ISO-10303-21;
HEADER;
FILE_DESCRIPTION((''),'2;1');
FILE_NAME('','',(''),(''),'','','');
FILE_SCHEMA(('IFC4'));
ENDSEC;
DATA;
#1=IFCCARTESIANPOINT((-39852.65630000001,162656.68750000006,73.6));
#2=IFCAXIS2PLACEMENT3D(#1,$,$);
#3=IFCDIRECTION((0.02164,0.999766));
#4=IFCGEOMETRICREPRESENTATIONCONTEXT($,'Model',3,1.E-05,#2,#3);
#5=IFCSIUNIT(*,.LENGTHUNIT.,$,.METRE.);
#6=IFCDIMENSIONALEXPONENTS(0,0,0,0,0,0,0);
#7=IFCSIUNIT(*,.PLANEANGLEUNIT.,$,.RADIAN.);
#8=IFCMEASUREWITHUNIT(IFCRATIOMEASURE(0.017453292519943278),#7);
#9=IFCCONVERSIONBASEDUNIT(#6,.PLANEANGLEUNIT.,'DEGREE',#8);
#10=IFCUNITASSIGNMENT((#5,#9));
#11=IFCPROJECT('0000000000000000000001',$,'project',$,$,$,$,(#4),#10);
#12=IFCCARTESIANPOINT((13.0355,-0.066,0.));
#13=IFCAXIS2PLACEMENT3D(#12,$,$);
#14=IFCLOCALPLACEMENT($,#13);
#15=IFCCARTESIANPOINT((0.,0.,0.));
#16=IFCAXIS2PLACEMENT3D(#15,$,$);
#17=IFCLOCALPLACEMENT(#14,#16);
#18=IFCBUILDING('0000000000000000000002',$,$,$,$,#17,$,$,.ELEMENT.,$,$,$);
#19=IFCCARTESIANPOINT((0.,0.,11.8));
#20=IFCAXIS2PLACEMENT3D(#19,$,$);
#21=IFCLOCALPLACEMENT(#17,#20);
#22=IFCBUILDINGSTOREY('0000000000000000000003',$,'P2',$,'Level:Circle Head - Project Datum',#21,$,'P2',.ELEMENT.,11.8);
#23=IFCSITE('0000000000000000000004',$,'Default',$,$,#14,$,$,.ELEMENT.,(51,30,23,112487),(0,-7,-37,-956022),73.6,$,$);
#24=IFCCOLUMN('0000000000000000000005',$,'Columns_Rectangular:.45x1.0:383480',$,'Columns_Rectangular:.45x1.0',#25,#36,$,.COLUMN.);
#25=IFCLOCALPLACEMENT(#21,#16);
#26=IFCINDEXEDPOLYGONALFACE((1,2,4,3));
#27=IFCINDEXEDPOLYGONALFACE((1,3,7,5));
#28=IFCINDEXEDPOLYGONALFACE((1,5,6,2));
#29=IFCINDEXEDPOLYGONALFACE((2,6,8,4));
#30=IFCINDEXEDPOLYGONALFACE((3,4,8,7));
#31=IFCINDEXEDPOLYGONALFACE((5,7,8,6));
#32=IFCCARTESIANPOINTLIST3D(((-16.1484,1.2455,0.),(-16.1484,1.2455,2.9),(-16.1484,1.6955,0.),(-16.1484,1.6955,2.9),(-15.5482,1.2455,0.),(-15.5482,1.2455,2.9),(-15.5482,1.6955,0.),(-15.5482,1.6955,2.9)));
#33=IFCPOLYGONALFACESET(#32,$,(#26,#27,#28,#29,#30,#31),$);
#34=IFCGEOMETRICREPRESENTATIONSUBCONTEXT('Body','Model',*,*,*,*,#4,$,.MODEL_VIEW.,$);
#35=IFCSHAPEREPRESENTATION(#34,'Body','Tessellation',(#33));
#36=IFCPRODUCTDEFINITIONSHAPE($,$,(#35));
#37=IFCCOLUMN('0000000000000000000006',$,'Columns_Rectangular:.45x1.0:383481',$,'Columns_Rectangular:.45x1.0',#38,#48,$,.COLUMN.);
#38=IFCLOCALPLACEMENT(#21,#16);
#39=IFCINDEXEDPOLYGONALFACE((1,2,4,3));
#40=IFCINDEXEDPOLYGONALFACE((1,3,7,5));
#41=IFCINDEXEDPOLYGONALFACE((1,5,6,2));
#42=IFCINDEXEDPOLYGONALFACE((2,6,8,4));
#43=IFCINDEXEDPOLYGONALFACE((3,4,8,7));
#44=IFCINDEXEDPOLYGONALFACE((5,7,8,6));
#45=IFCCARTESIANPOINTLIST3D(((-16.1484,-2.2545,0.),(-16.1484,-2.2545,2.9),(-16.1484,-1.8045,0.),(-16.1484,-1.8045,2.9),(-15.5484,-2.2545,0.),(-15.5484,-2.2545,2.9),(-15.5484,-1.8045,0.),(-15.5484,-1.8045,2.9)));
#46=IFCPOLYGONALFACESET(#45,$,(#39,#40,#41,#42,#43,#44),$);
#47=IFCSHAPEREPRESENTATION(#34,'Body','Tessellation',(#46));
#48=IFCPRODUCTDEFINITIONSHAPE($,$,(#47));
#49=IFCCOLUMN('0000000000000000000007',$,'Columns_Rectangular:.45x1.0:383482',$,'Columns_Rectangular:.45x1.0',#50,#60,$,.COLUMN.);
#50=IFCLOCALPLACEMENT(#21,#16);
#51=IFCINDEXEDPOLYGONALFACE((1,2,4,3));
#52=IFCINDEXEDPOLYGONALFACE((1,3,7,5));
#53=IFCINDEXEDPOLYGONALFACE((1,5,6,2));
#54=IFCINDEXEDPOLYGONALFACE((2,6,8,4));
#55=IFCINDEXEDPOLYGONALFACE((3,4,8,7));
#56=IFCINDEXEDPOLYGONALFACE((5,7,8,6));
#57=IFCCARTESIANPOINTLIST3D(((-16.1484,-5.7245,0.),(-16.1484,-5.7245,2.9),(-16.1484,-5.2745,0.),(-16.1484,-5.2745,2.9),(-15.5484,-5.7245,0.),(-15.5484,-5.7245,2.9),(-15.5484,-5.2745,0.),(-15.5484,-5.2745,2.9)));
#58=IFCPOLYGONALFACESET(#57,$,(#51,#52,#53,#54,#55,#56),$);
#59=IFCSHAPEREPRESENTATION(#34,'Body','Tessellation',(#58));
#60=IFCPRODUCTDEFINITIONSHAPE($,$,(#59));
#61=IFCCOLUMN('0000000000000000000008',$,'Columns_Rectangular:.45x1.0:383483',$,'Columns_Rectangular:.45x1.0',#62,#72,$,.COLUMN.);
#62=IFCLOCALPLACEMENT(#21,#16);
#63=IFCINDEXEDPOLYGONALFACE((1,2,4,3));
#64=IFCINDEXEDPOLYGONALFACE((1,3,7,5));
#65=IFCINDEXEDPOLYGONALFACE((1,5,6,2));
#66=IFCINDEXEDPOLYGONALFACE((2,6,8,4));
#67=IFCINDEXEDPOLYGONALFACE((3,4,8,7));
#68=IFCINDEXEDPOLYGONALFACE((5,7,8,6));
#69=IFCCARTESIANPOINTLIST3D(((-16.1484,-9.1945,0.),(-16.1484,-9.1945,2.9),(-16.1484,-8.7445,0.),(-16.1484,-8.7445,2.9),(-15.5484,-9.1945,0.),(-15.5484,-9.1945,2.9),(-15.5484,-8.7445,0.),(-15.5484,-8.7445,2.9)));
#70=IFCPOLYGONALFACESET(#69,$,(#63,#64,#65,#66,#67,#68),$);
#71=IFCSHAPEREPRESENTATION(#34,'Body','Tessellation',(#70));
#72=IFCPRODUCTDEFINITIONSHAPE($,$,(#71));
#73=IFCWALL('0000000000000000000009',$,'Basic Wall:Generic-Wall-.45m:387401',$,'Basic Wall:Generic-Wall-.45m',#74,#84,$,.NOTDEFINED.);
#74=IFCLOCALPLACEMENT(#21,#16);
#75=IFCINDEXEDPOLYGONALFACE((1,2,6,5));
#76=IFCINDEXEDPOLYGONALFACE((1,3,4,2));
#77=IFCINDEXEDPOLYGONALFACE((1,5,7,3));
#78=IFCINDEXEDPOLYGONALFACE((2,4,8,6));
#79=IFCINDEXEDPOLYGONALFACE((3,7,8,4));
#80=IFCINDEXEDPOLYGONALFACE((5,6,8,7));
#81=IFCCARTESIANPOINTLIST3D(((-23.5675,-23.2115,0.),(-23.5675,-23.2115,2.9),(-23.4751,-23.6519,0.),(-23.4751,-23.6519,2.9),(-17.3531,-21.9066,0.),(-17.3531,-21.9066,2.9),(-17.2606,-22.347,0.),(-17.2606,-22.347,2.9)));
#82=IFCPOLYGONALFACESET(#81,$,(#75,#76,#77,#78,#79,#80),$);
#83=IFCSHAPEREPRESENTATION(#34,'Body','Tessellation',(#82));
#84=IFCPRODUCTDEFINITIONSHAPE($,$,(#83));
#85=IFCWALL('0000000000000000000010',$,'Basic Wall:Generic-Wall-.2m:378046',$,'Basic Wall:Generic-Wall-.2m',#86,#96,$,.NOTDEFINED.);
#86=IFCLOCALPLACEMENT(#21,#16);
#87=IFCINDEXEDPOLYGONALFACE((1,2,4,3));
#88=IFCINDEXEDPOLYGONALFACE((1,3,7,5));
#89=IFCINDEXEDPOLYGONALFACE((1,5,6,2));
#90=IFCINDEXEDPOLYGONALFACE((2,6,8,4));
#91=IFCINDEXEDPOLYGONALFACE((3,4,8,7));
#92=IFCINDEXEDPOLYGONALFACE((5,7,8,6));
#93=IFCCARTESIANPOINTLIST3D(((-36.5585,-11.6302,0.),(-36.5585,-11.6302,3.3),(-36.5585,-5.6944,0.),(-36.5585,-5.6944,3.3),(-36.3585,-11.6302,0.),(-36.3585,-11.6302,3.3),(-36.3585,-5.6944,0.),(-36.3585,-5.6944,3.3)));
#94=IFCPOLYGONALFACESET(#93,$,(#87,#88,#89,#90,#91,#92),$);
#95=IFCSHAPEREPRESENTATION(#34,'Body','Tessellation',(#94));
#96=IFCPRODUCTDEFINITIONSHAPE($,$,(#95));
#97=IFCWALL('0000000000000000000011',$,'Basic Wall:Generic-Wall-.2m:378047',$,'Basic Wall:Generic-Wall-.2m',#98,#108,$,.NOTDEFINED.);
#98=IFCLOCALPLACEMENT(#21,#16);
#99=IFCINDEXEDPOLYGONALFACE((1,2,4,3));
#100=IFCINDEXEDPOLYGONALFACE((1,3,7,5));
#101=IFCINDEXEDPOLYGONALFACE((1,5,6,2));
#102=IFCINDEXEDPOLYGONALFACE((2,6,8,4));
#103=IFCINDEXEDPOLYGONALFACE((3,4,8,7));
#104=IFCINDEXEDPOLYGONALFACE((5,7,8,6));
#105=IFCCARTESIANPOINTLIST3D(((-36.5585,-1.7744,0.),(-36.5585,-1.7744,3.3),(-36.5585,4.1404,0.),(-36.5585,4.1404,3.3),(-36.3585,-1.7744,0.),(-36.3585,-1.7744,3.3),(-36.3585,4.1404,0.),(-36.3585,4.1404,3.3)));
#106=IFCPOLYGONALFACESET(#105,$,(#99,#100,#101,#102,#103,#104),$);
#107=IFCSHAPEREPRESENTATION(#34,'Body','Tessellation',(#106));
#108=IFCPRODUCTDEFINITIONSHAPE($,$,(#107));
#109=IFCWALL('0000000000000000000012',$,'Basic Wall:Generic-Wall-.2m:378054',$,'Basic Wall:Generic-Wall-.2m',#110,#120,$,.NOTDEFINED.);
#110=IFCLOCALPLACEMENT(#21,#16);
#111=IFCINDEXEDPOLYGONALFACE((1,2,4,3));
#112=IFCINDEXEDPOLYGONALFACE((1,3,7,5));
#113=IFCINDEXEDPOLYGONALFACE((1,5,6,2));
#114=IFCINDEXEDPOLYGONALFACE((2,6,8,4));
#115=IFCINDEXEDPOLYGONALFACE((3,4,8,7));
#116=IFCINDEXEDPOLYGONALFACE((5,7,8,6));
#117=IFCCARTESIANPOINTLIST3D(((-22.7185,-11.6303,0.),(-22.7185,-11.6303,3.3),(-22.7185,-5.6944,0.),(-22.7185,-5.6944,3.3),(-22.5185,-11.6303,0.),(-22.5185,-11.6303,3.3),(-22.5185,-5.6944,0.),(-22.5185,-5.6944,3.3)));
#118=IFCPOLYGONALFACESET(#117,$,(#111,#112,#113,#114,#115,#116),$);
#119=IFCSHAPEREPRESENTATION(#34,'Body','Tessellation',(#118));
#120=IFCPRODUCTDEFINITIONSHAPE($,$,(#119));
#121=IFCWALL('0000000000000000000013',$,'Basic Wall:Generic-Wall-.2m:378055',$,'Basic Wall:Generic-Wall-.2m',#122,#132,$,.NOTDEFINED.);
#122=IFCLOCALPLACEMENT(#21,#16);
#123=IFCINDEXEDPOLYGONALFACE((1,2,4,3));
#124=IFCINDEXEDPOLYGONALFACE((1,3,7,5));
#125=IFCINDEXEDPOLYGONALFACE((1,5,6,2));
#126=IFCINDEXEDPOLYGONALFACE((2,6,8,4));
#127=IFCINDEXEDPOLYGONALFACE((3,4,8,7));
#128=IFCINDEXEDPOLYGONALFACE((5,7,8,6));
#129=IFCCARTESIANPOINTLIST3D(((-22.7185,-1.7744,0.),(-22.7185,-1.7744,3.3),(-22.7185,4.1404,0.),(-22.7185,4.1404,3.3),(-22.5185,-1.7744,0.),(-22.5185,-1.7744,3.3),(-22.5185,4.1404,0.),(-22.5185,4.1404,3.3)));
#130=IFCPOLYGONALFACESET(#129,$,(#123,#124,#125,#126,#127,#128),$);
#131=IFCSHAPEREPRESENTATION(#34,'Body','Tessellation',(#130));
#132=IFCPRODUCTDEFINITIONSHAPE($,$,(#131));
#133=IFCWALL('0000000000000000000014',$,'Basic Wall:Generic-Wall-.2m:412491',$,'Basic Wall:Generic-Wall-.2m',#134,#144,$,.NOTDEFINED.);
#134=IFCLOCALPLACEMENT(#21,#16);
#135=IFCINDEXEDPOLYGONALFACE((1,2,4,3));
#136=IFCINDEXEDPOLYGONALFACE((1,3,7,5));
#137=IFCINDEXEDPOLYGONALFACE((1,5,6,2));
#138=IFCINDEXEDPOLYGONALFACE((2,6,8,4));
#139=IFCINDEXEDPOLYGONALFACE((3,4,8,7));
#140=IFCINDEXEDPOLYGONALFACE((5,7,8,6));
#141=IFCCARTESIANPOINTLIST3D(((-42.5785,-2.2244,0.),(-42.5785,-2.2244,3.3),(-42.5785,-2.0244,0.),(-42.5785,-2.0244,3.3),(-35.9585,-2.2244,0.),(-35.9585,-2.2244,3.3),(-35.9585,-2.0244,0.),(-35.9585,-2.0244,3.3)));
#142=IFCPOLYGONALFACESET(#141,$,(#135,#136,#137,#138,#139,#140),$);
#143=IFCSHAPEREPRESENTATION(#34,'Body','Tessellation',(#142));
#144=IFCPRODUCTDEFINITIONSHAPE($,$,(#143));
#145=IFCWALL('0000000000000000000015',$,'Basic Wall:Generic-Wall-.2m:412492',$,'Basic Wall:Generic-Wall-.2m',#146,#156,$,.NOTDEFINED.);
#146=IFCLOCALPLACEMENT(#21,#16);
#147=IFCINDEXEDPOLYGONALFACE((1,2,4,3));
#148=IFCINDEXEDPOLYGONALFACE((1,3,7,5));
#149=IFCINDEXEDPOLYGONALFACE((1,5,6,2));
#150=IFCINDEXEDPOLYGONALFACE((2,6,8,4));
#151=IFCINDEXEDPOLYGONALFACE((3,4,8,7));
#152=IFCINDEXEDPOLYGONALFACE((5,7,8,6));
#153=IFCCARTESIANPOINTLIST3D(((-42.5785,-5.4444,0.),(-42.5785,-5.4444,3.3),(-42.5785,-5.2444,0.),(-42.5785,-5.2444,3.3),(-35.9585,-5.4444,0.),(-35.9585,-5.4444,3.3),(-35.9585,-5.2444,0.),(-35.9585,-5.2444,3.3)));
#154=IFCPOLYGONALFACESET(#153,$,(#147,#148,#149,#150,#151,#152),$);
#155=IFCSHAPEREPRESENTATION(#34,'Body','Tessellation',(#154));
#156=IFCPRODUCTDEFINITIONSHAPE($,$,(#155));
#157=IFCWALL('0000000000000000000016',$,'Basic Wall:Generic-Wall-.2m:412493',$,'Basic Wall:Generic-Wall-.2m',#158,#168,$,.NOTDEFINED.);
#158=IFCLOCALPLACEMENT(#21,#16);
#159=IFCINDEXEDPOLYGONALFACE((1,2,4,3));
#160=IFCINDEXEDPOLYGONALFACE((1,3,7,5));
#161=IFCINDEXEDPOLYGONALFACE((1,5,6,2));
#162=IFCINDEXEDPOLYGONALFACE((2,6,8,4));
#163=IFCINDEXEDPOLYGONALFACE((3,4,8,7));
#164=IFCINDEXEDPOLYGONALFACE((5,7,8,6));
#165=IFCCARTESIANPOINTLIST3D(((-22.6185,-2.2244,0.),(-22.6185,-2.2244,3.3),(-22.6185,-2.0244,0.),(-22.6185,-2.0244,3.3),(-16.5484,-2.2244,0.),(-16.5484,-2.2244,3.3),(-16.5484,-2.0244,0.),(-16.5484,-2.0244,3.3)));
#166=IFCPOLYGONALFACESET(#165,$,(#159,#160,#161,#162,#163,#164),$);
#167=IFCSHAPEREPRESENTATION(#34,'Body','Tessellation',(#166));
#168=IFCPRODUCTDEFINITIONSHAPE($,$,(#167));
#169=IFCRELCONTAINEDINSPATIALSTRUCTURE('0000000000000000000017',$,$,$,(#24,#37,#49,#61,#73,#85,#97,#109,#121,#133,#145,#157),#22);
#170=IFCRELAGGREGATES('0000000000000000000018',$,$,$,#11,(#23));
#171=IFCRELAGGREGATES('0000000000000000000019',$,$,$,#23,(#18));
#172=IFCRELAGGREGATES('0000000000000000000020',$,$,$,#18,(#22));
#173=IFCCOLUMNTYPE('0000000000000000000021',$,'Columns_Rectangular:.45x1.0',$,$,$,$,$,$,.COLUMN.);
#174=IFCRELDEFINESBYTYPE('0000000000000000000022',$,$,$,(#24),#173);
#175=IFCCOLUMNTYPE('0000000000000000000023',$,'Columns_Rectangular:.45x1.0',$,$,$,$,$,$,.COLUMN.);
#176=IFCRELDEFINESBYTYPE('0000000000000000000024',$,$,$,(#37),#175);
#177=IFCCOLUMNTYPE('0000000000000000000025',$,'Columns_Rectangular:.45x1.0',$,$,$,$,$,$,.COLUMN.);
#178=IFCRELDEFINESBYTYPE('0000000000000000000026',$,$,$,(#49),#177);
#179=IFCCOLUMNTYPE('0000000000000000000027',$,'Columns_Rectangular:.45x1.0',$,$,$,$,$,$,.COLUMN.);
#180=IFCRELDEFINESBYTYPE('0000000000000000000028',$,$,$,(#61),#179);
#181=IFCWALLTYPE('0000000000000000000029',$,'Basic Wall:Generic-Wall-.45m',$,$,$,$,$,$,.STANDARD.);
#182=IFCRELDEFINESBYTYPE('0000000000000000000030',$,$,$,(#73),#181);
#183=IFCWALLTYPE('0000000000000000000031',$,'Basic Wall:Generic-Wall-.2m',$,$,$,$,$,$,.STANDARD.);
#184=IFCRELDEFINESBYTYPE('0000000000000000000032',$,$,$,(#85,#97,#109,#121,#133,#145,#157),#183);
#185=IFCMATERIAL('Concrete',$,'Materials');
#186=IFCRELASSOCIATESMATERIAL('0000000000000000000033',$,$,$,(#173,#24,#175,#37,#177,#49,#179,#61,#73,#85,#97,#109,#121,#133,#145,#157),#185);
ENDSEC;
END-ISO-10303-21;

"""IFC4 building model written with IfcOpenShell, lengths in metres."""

from ifc_helpers import new_model, entity, si_unit, converted_unit, direction, frame, origin, place, context, subcontext, project, spatial, indexed_curve, outline, extrude, source, transform, mapped, material, type_object, type_shapes, element, save


model = new_model("IFC4")

# Units and contexts
model_context = context("Model", 3, precision=1e-05, world=frame((-39852.65630000001, 162656.68750000006, 73.6)), true_north=direction((0.02164, 0.999766)))
body_context = subcontext(model_context, "Body", "Model", "MODEL_VIEW")
ifc_project = project(units=[si_unit("LENGTHUNIT", "METRE"), converted_unit("PLANEANGLEUNIT", "DEGREE", entity("IfcRatioMeasure", 0.017453292519943278), si_unit("PLANEANGLEUNIT", "RADIAN"), dimensions=[0, 0, 0, 0, 0, 0, 0])], contexts=[model_context])

# Site, building, storey
site_placement = place(None, frame((13.0355, -0.066, 0.0)))
site = spatial("IfcSite", under=ifc_project, at=site_placement, Name="Default", CompositionType="ELEMENT", RefLatitude=(51, 30, 23, 112487), RefLongitude=(0, -7, -37, -956022), RefElevation=73.6)
building_placement = place(site_placement, origin())
building = spatial("IfcBuilding", under=site, at=building_placement, CompositionType="ELEMENT")
storey_placement = place(building_placement, frame((0.0, 0.0, 11.8)))
storey = spatial("IfcBuildingStorey", under=building, at=storey_placement, Name="P2", ObjectType="Level:Circle Head - Project Datum", LongName="P2", CompositionType="ELEMENT", Elevation=11.8)

# Columns
ifc_material = material(Name="Concrete", Category="Materials")
column_type_1 = type_object("IfcColumnType", Name="Columns_Rectangular:.45x1.0", PredefinedType="COLUMN", material=ifc_material)
shared_shape_1 = source(origin(), body_context, "Body", "SweptSolid", [
    extrude(outline(indexed_curve([(-0.225, -0.3001), (0.225, -0.3001), (0.225, 0.3001), (-0.225, 0.3001), (-0.225, -0.3001)], self_intersect=False)), frame((-15.8483, 1.4705, 11.8), z_axis=(0.0, 0.0, 1.0), x_axis=(0.0, -1.0, 0.0)), (0.0, 0.0, 1.0), 2.9),
])
type_shapes(column_type_1, [shared_shape_1])
column_1_placement = place(storey_placement, frame((0.0, 0.0, -11.8)))
element("IfcColumn", 1, at=column_1_placement, inside=storey, type_object=column_type_1, material=ifc_material, Name="Columns_Rectangular:.45x1.0:383480", ObjectType="Columns_Rectangular:.45x1.0", PredefinedType="COLUMN", context=body_context, shape_type="MappedRepresentation", body=[
    mapped(shared_shape_1, transform((0.0, 0.0, 0.0), scale=1.0)),
])
column_type_2 = type_object("IfcColumnType", Name="Columns_Rectangular:.45x1.0", PredefinedType="COLUMN", material=ifc_material)
shared_shape_2 = source(origin(), body_context, "Body", "SweptSolid", [
    extrude(outline(indexed_curve([(-0.225, -0.3), (0.225, -0.3), (0.225, 0.3), (-0.225, 0.3), (-0.225, -0.3)], self_intersect=False)), frame((-15.8484, -2.0295, 11.8), z_axis=(0.0, 0.0, 1.0), x_axis=(0.0, -1.0, 0.0)), (0.0, 0.0, 1.0), 2.9),
])
type_shapes(column_type_2, [shared_shape_2])
column_2_placement = place(storey_placement, frame((0.0, 0.0, -11.8)))
element("IfcColumn", 2, at=column_2_placement, inside=storey, type_object=column_type_2, material=ifc_material, Name="Columns_Rectangular:.45x1.0:383481", ObjectType="Columns_Rectangular:.45x1.0", PredefinedType="COLUMN", context=body_context, shape_type="MappedRepresentation", body=[
    mapped(shared_shape_2, transform((0.0, 0.0, 0.0), scale=1.0)),
])
column_type_3 = type_object("IfcColumnType", Name="Columns_Rectangular:.45x1.0", PredefinedType="COLUMN", material=ifc_material)
shared_shape_3 = source(origin(), body_context, "Body", "SweptSolid", [
    extrude(outline(indexed_curve([(-0.225, -0.3), (0.225, -0.3), (0.225, 0.3), (-0.225, 0.3), (-0.225, -0.3)], self_intersect=False)), frame((-15.8484, -5.4995, 11.8), z_axis=(0.0, 0.0, 1.0), x_axis=(0.0, -1.0, 0.0)), (0.0, 0.0, 1.0), 2.9),
])
type_shapes(column_type_3, [shared_shape_3])
column_3_placement = place(storey_placement, frame((0.0, 0.0, -11.8)))
element("IfcColumn", 3, at=column_3_placement, inside=storey, type_object=column_type_3, material=ifc_material, Name="Columns_Rectangular:.45x1.0:383482", ObjectType="Columns_Rectangular:.45x1.0", PredefinedType="COLUMN", context=body_context, shape_type="MappedRepresentation", body=[
    mapped(shared_shape_3, transform((0.0, 0.0, 0.0), scale=1.0)),
])
column_type_4 = type_object("IfcColumnType", Name="Columns_Rectangular:.45x1.0", PredefinedType="COLUMN", material=ifc_material)
shared_shape_4 = source(origin(), body_context, "Body", "SweptSolid", [
    extrude(outline(indexed_curve([(-0.225, -0.3), (0.225, -0.3), (0.225, 0.3), (-0.225, 0.3), (-0.225, -0.3)], self_intersect=False)), frame((-15.8484, -8.9695, 11.8), z_axis=(0.0, 0.0, 1.0), x_axis=(0.0, -1.0, 0.0)), (0.0, 0.0, 1.0), 2.9),
])
type_shapes(column_type_4, [shared_shape_4])
column_4_placement = place(storey_placement, frame((0.0, 0.0, -11.8)))
element("IfcColumn", 4, at=column_4_placement, inside=storey, type_object=column_type_4, material=ifc_material, Name="Columns_Rectangular:.45x1.0:383483", ObjectType="Columns_Rectangular:.45x1.0", PredefinedType="COLUMN", context=body_context, shape_type="MappedRepresentation", body=[
    mapped(shared_shape_4, transform((0.0, 0.0, 0.0), scale=1.0)),
])

# Walls
wall_type_1 = type_object("IfcWallType", Name="Basic Wall:Generic-Wall-.45m", PredefinedType="STANDARD")
wall_1_placement = place(storey_placement, frame((-23.5213, -23.4317, 0.0), z_axis=(0.0, 0.0, 1.0), x_axis=(0.978657, 0.2055, 0.0)))
element("IfcWall", 5, at=wall_1_placement, inside=storey, type_object=wall_type_1, material=ifc_material, Name="Basic Wall:Generic-Wall-.45m:387401", ObjectType="Basic Wall:Generic-Wall-.45m", PredefinedType="NOTDEFINED", context=body_context, shape_type="SweptSolid", body=[
    extrude(outline(indexed_curve([(6.35, 0.225), (0.0, 0.225), (0.0, -0.225), (6.35, -0.225), (6.35, 0.225)], self_intersect=False)), origin(), (0.0, 0.0, 1.0), 2.9),
])
wall_type_2 = type_object("IfcWallType", Name="Basic Wall:Generic-Wall-.2m", PredefinedType="STANDARD")
wall_2_placement = place(storey_placement, frame((-36.4585, -5.6944, 0.0), z_axis=(0.0, 0.0, 1.0), x_axis=(0.0, -1.0, 0.0)))
element("IfcWall", 6, at=wall_2_placement, inside=storey, type_object=wall_type_2, material=ifc_material, Name="Basic Wall:Generic-Wall-.2m:378046", ObjectType="Basic Wall:Generic-Wall-.2m", PredefinedType="NOTDEFINED", context=body_context, shape_type="SweptSolid", body=[
    extrude(outline(indexed_curve([(5.9357, 0.1), (0.0, 0.1), (0.0, -0.1), (5.9357, -0.1), (5.9357, 0.1)], self_intersect=False)), origin(), (0.0, 0.0, 1.0), 3.3),
])
wall_3_placement = place(storey_placement, frame((-36.4585, -1.7744, 0.0), z_axis=(0.0, 0.0, 1.0), x_axis=(0.0, 1.0, 0.0)))
element("IfcWall", 7, at=wall_3_placement, inside=storey, type_object=wall_type_2, material=ifc_material, Name="Basic Wall:Generic-Wall-.2m:378047", ObjectType="Basic Wall:Generic-Wall-.2m", PredefinedType="NOTDEFINED", context=body_context, shape_type="SweptSolid", body=[
    extrude(outline(indexed_curve([(5.9149, 0.1), (0.0, 0.1), (0.0, -0.1), (5.9149, -0.1), (5.9149, 0.1)], self_intersect=False)), origin(), (0.0, 0.0, 1.0), 3.3),
])
wall_4_placement = place(storey_placement, frame((-22.6185, -5.6944, 0.0), z_axis=(0.0, 0.0, 1.0), x_axis=(0.0, -1.0, 0.0)))
element("IfcWall", 8, at=wall_4_placement, inside=storey, type_object=wall_type_2, material=ifc_material, Name="Basic Wall:Generic-Wall-.2m:378054", ObjectType="Basic Wall:Generic-Wall-.2m", PredefinedType="NOTDEFINED", context=body_context, shape_type="SweptSolid", body=[
    extrude(outline(indexed_curve([(5.9359, 0.1), (0.0, 0.1), (0.0, -0.1), (5.9359, -0.1), (5.9359, 0.1)], self_intersect=False)), origin(), (0.0, 0.0, 1.0), 3.3),
])
wall_5_placement = place(storey_placement, frame((-22.6185, -1.7744, 0.0), z_axis=(0.0, 0.0, 1.0), x_axis=(0.0, 1.0, 0.0)))
element("IfcWall", 9, at=wall_5_placement, inside=storey, type_object=wall_type_2, material=ifc_material, Name="Basic Wall:Generic-Wall-.2m:378055", ObjectType="Basic Wall:Generic-Wall-.2m", PredefinedType="NOTDEFINED", context=body_context, shape_type="SweptSolid", body=[
    extrude(outline(indexed_curve([(5.9149, 0.1), (0.0, 0.1), (0.0, -0.1), (5.9149, -0.1), (5.9149, 0.1)], self_intersect=False)), origin(), (0.0, 0.0, 1.0), 3.3),
])
wall_6_placement = place(storey_placement, frame((-35.9585, -2.1244, 0.0), z_axis=(0.0, 0.0, 1.0), x_axis=(-1.0, 0.0, 0.0)))
element("IfcWall", 10, at=wall_6_placement, inside=storey, type_object=wall_type_2, material=ifc_material, Name="Basic Wall:Generic-Wall-.2m:412491", ObjectType="Basic Wall:Generic-Wall-.2m", PredefinedType="NOTDEFINED", context=body_context, shape_type="SweptSolid", body=[
    extrude(outline(indexed_curve([(6.6201, 0.1), (0.0, 0.1), (0.0, -0.1), (6.6201, -0.1), (6.6201, 0.1)], self_intersect=False)), origin(), (0.0, 0.0, 1.0), 3.3),
])
wall_7_placement = place(storey_placement, frame((-35.9585, -5.3444, 0.0), z_axis=(0.0, 0.0, 1.0), x_axis=(-1.0, 0.0, 0.0)))
element("IfcWall", 11, at=wall_7_placement, inside=storey, type_object=wall_type_2, material=ifc_material, Name="Basic Wall:Generic-Wall-.2m:412492", ObjectType="Basic Wall:Generic-Wall-.2m", PredefinedType="NOTDEFINED", context=body_context, shape_type="SweptSolid", body=[
    extrude(outline(indexed_curve([(6.62, 0.1), (0.0, 0.1), (0.0, -0.1), (6.62, -0.1), (6.62, 0.1)], self_intersect=False)), origin(), (0.0, 0.0, 1.0), 3.3),
])
wall_8_placement = place(storey_placement, frame((-22.6185, -2.1244, 0.0)))
element("IfcWall", 12, at=wall_8_placement, inside=storey, type_object=wall_type_2, material=ifc_material, Name="Basic Wall:Generic-Wall-.2m:412493", ObjectType="Basic Wall:Generic-Wall-.2m", PredefinedType="NOTDEFINED", context=body_context, shape_type="SweptSolid", body=[
    extrude(outline(indexed_curve([(6.0701, 0.1), (0.0, 0.1), (0.0, -0.1), (6.0701, -0.1), (6.0701, 0.1)], self_intersect=False)), origin(), (0.0, 0.0, 1.0), 3.3),
])

save(model, "model.ifc")
